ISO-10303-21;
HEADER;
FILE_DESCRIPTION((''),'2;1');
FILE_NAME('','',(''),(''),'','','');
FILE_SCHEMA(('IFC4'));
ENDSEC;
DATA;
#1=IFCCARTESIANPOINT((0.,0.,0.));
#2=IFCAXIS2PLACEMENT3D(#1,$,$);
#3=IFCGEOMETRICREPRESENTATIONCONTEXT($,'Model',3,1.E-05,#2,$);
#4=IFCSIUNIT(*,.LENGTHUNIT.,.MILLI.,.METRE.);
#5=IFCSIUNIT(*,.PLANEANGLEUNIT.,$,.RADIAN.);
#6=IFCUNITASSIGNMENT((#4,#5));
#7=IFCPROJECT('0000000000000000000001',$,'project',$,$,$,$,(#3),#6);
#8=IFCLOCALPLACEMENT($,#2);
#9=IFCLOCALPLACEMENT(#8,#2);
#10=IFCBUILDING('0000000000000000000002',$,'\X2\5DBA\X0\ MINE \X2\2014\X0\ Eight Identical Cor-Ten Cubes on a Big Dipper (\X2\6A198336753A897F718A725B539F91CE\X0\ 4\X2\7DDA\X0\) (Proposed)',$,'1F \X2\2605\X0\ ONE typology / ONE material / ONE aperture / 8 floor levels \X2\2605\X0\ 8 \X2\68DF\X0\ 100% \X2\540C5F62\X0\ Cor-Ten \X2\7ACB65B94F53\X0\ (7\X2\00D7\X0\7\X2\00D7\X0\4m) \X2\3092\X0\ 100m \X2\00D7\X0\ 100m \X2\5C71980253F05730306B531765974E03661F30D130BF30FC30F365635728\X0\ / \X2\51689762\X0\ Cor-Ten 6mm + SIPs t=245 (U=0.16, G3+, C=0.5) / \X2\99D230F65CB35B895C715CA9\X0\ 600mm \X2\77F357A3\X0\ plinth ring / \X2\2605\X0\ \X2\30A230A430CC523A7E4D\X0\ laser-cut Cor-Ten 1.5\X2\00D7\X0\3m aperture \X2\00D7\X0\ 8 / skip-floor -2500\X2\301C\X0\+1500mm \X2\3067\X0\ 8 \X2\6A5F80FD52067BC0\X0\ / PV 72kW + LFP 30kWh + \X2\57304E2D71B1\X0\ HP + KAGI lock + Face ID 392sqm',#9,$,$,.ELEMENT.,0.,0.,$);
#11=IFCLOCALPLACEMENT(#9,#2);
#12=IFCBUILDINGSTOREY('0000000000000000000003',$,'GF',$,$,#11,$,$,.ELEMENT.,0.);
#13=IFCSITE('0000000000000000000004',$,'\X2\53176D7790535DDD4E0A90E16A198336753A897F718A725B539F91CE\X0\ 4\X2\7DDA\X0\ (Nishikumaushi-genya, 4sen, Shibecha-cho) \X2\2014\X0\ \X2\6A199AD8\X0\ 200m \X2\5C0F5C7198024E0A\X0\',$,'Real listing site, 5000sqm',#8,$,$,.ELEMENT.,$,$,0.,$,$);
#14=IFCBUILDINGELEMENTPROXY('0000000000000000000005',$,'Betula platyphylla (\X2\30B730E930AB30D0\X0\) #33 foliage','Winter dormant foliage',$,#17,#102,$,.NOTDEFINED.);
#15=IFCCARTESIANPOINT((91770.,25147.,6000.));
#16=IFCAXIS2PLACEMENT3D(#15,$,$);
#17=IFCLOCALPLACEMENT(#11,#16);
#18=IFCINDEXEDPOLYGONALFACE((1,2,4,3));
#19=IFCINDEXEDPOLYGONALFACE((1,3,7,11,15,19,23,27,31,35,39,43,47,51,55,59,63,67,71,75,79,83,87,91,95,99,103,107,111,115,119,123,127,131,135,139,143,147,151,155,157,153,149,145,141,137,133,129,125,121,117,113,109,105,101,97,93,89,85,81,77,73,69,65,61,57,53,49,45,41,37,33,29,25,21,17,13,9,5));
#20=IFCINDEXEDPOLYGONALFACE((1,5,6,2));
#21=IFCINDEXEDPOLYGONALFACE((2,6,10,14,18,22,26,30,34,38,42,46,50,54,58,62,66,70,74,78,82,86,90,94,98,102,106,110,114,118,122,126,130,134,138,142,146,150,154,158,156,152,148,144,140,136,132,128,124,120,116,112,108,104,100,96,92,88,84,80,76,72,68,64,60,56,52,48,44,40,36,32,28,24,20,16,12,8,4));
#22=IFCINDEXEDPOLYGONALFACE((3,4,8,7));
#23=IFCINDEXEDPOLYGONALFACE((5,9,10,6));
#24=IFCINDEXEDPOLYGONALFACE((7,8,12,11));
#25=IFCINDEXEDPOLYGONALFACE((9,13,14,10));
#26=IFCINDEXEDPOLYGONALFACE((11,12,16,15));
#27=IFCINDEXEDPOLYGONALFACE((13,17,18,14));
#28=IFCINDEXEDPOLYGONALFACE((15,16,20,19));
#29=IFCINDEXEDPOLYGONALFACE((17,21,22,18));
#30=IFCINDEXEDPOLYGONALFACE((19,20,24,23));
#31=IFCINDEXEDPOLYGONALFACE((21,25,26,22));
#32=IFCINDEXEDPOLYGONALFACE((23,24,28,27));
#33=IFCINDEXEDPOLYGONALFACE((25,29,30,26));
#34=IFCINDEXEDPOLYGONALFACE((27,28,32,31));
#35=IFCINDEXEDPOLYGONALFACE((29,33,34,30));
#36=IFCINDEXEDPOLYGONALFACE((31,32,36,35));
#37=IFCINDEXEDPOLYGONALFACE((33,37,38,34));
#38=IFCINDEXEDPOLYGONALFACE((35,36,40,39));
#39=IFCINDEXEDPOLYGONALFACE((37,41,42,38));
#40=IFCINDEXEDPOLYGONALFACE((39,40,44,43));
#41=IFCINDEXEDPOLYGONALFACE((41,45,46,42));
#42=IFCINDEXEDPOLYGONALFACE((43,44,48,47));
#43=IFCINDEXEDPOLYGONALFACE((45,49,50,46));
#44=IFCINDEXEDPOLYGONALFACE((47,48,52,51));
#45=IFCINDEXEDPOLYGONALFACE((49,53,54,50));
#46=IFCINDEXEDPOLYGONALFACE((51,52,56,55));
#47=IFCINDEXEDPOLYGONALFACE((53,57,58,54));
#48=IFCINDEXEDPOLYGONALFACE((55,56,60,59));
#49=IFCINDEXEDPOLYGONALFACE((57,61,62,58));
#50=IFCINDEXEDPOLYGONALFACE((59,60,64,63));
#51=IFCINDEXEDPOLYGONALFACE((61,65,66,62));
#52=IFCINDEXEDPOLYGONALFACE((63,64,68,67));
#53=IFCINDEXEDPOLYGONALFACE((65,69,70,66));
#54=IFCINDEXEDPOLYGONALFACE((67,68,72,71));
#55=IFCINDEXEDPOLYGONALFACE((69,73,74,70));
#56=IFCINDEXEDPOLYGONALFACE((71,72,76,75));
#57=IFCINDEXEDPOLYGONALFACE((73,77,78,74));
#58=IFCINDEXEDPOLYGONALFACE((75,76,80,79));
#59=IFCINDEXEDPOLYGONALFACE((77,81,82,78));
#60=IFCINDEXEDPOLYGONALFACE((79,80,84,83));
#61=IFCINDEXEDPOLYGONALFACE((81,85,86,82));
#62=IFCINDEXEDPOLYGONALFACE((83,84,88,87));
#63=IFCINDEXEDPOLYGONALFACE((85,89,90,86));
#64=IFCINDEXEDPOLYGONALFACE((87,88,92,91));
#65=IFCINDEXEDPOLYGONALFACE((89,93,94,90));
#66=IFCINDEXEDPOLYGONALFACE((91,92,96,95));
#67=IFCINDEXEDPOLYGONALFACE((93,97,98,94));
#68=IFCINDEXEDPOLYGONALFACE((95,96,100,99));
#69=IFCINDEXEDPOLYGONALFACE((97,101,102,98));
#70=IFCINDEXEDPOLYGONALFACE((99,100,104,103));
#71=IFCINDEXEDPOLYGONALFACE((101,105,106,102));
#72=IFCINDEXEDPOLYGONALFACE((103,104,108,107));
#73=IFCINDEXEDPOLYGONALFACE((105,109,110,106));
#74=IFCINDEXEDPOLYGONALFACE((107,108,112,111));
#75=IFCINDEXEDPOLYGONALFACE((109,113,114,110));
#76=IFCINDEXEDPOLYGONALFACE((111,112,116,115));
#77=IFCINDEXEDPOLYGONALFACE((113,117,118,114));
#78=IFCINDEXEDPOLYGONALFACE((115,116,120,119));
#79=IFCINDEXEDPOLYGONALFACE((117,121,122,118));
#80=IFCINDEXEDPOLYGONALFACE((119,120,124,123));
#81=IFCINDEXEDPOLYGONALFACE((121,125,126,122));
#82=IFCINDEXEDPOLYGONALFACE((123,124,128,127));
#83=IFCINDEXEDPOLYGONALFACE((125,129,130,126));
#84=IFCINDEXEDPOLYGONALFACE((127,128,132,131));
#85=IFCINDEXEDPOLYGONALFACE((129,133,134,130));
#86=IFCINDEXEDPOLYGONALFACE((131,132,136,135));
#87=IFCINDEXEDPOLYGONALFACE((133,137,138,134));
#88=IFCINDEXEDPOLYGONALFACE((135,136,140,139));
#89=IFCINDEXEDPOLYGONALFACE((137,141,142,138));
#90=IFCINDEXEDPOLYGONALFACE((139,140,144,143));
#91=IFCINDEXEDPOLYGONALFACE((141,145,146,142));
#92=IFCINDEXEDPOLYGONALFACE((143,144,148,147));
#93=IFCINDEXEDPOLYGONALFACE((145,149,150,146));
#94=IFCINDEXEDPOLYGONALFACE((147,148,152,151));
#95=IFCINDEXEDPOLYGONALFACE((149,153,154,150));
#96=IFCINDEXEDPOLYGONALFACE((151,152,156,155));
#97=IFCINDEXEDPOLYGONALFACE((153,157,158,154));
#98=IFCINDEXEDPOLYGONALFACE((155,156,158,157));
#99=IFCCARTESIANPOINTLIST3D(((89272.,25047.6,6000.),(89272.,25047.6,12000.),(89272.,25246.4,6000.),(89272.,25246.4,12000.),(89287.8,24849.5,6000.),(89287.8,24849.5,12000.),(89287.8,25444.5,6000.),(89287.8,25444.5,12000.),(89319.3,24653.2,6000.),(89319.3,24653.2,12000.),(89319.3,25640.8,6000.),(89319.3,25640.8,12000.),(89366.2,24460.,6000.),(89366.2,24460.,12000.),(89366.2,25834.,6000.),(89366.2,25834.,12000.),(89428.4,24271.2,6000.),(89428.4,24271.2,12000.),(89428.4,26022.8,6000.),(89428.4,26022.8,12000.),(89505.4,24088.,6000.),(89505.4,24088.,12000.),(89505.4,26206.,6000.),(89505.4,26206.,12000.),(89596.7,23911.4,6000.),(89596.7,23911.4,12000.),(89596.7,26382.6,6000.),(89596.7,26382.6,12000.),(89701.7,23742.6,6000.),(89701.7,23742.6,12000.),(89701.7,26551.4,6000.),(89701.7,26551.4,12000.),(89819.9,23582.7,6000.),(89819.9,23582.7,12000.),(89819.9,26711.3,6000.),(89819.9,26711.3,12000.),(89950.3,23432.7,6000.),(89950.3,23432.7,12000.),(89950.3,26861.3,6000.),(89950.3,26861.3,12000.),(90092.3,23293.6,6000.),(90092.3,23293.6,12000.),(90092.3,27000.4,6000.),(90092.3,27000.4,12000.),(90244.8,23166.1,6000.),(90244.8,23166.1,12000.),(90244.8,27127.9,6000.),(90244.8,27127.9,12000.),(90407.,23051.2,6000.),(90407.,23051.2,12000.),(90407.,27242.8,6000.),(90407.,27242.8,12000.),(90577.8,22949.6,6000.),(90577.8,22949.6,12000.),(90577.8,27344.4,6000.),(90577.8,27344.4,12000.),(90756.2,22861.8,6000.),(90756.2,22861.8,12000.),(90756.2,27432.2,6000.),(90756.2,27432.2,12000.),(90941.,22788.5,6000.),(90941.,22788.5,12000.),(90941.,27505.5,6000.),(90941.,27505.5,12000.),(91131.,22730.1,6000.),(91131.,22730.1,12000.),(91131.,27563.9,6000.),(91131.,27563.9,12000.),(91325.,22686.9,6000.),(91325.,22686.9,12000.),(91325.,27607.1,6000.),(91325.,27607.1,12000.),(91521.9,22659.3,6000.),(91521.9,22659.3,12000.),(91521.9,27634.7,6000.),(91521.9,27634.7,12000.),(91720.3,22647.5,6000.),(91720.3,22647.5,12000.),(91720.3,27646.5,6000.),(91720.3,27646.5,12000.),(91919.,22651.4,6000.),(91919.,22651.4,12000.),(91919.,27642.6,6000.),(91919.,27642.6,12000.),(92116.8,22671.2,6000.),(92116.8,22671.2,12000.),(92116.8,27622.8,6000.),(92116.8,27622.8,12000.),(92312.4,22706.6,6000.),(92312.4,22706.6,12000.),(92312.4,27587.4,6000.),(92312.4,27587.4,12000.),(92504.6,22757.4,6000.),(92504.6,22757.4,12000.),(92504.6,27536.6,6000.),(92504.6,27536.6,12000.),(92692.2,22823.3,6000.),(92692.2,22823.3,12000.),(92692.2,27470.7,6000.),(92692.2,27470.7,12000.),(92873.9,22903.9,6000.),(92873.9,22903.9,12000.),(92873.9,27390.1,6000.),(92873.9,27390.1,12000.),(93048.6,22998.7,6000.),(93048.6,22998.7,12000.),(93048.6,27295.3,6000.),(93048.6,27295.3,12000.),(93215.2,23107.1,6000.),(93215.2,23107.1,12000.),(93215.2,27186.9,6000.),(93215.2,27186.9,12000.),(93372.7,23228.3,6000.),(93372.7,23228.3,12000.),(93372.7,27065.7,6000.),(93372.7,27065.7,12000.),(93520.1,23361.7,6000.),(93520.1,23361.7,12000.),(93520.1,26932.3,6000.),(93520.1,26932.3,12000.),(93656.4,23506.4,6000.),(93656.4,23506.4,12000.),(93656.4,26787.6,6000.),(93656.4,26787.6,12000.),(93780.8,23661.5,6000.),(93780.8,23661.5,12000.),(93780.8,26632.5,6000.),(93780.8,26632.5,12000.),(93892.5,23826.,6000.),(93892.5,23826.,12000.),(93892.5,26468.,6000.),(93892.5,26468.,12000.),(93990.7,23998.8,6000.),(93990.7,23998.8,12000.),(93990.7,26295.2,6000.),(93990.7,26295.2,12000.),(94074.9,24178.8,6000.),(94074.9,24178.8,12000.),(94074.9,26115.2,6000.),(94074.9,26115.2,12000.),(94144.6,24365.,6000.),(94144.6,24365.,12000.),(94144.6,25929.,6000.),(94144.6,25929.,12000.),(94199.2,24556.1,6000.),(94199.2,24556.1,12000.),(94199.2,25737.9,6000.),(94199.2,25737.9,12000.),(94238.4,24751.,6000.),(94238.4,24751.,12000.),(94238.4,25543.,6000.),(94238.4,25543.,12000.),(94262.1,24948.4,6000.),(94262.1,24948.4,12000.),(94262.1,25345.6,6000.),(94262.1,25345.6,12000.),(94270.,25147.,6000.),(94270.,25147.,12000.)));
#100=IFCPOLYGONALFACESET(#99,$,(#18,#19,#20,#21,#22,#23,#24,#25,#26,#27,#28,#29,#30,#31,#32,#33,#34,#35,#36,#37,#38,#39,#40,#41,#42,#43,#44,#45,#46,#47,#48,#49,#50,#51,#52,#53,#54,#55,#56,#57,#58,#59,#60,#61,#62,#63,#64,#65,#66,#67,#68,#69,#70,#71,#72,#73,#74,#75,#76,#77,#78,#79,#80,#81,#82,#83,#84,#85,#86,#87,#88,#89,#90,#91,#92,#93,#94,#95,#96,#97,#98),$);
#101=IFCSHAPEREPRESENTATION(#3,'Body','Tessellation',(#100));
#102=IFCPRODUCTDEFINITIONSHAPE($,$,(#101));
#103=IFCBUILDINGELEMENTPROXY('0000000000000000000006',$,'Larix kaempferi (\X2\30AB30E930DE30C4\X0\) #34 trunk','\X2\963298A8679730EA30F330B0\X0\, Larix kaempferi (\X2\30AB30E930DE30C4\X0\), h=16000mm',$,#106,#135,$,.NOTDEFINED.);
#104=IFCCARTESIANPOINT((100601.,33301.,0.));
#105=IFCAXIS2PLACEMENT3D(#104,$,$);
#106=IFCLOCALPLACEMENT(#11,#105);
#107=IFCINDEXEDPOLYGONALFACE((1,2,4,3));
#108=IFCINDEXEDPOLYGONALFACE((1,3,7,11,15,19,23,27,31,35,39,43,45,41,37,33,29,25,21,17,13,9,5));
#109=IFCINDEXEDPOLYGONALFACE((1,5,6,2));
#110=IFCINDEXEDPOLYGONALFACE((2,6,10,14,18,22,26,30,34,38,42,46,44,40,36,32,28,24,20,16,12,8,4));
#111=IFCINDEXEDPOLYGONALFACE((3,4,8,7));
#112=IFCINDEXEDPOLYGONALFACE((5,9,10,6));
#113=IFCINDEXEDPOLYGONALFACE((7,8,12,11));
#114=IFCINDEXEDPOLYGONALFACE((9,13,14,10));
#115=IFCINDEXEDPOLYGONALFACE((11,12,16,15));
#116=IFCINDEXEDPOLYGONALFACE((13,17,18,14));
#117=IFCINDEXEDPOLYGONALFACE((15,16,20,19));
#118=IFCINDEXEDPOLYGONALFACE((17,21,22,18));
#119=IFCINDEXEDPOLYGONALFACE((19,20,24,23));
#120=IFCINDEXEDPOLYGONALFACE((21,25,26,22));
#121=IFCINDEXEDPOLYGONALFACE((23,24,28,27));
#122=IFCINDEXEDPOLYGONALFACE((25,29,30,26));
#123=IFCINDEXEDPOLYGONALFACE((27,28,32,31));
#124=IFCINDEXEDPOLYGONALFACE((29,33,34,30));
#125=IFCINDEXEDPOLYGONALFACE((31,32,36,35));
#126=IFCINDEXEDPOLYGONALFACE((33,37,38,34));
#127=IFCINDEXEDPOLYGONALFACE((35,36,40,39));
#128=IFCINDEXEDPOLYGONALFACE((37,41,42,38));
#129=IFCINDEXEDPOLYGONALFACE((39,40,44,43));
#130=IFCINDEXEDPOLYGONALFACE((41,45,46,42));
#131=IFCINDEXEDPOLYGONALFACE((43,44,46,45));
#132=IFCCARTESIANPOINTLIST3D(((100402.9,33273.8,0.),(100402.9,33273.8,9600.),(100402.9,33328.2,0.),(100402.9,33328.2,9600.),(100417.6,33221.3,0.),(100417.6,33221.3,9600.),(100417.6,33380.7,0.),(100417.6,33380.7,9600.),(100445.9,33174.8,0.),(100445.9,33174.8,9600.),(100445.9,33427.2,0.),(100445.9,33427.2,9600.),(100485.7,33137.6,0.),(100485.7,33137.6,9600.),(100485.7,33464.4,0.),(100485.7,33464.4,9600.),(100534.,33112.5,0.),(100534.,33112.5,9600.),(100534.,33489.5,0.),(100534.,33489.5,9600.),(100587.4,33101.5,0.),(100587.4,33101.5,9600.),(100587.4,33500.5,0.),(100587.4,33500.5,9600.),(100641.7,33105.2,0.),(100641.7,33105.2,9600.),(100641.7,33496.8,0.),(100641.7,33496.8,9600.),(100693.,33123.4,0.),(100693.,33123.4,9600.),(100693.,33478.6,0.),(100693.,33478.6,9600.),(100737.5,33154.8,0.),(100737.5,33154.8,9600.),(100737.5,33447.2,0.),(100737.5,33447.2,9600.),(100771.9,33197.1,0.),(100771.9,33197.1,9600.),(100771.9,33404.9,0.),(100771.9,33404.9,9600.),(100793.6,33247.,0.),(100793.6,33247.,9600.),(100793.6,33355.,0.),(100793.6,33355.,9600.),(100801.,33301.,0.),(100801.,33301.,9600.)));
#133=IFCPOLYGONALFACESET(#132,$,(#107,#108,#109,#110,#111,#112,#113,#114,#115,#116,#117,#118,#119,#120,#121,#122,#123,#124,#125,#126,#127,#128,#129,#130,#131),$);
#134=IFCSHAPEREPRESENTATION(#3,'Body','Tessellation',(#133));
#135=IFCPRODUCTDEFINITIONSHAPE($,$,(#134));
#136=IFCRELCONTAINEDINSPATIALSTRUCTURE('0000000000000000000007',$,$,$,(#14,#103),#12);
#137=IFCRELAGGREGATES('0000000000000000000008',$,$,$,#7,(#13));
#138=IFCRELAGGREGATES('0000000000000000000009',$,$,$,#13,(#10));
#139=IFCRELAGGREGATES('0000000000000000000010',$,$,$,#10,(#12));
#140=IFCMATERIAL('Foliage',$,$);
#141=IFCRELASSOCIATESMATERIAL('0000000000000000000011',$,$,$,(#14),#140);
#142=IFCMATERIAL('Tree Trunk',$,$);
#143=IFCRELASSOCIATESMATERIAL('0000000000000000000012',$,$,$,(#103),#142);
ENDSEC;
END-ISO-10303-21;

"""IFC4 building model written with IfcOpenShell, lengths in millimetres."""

from ifc_helpers import new_model, si_unit, frame, origin, origin_2d, place, context, project, spatial, circle, extrude, material, element, save


model = new_model("IFC4")

# Units and contexts
model_context = context("Model", 3, precision=1e-05, world=origin())
ifc_project = project(units=[si_unit("LENGTHUNIT", "METRE", prefix="MILLI"), si_unit("PLANEANGLEUNIT", "RADIAN")], contexts=[model_context])

# Site, building, storey
site_placement = place(None, origin())
site = spatial("IfcSite", under=ifc_project, at=site_placement, Name="北海道川上郡標茶町西熊牛原野 4線 (Nishikumaushi-genya, 4sen, Shibecha-cho) — 標高 200m 小山頂上", ObjectType="Real listing site, 5000sqm", CompositionType="ELEMENT", RefElevation=0.0)
building_placement = place(site_placement, origin())
building = spatial("IfcBuilding", under=site, at=building_placement, Name="嶺 MINE — Eight Identical Cor-Ten Cubes on a Big Dipper (標茶町西熊牛原野 4線) (Proposed)", ObjectType="1F ★ ONE typology / ONE material / ONE aperture / 8 floor levels ★ 8 棟 100% 同形 Cor-Ten 立方体 (7×7×4m) を 100m × 100m 山頂台地に北斗七星パターン散在 / 全面 Cor-Ten 6mm + SIPs t=245 (U=0.16, G3+, C=0.5) / 駒ヶ岳安山岩 600mm 石垣 plinth ring / ★ アイヌ刺繍 laser-cut Cor-Ten 1.5×3m aperture × 8 / skip-floor -2500〜+1500mm で 8 機能分節 / PV 72kW + LFP 30kWh + 地中熱 HP + KAGI lock + Face ID 392sqm", CompositionType="ELEMENT", ElevationOfRefHeight=0.0, ElevationOfTerrain=0.0)
storey_placement = place(building_placement, origin())
storey = spatial("IfcBuildingStorey", under=building, at=storey_placement, Name="GF", CompositionType="ELEMENT", Elevation=0.0)

# Building element proxies
ifc_material_1 = material(Name="Tree Trunk")
ifc_material_2 = material(Name="Foliage")
proxy_1_placement = place(storey_placement, frame((91770.0, 25147.0, 6000.0)))
element("IfcBuildingElementProxy", 1, at=proxy_1_placement, inside=storey, material=ifc_material_2, Name="Betula platyphylla (シラカバ) #33 foliage", Description="Winter dormant foliage", PredefinedType="NOTDEFINED", context=model_context, shape_type="SweptSolid", body=[
    extrude(circle(Radius=2500.0, at=origin_2d()), frame((91770.0, 25147.0, 6000.0)), (0.0, 0.0, 1.0), 6000.0),
])
proxy_2_placement = place(storey_placement, frame((100601.0, 33301.0, 0.0)))
element("IfcBuildingElementProxy", 2, at=proxy_2_placement, inside=storey, material=ifc_material_1, Name="Larix kaempferi (カラマツ) #34 trunk", Description="防風林リング, Larix kaempferi (カラマツ), h=16000mm", PredefinedType="NOTDEFINED", context=model_context, shape_type="SweptSolid", body=[
    extrude(circle(Radius=200.0, at=origin_2d()), frame((100601.0, 33301.0, 0.0)), (0.0, 0.0, 1.0), 9600.0),
])

save(model, "model.ifc")
